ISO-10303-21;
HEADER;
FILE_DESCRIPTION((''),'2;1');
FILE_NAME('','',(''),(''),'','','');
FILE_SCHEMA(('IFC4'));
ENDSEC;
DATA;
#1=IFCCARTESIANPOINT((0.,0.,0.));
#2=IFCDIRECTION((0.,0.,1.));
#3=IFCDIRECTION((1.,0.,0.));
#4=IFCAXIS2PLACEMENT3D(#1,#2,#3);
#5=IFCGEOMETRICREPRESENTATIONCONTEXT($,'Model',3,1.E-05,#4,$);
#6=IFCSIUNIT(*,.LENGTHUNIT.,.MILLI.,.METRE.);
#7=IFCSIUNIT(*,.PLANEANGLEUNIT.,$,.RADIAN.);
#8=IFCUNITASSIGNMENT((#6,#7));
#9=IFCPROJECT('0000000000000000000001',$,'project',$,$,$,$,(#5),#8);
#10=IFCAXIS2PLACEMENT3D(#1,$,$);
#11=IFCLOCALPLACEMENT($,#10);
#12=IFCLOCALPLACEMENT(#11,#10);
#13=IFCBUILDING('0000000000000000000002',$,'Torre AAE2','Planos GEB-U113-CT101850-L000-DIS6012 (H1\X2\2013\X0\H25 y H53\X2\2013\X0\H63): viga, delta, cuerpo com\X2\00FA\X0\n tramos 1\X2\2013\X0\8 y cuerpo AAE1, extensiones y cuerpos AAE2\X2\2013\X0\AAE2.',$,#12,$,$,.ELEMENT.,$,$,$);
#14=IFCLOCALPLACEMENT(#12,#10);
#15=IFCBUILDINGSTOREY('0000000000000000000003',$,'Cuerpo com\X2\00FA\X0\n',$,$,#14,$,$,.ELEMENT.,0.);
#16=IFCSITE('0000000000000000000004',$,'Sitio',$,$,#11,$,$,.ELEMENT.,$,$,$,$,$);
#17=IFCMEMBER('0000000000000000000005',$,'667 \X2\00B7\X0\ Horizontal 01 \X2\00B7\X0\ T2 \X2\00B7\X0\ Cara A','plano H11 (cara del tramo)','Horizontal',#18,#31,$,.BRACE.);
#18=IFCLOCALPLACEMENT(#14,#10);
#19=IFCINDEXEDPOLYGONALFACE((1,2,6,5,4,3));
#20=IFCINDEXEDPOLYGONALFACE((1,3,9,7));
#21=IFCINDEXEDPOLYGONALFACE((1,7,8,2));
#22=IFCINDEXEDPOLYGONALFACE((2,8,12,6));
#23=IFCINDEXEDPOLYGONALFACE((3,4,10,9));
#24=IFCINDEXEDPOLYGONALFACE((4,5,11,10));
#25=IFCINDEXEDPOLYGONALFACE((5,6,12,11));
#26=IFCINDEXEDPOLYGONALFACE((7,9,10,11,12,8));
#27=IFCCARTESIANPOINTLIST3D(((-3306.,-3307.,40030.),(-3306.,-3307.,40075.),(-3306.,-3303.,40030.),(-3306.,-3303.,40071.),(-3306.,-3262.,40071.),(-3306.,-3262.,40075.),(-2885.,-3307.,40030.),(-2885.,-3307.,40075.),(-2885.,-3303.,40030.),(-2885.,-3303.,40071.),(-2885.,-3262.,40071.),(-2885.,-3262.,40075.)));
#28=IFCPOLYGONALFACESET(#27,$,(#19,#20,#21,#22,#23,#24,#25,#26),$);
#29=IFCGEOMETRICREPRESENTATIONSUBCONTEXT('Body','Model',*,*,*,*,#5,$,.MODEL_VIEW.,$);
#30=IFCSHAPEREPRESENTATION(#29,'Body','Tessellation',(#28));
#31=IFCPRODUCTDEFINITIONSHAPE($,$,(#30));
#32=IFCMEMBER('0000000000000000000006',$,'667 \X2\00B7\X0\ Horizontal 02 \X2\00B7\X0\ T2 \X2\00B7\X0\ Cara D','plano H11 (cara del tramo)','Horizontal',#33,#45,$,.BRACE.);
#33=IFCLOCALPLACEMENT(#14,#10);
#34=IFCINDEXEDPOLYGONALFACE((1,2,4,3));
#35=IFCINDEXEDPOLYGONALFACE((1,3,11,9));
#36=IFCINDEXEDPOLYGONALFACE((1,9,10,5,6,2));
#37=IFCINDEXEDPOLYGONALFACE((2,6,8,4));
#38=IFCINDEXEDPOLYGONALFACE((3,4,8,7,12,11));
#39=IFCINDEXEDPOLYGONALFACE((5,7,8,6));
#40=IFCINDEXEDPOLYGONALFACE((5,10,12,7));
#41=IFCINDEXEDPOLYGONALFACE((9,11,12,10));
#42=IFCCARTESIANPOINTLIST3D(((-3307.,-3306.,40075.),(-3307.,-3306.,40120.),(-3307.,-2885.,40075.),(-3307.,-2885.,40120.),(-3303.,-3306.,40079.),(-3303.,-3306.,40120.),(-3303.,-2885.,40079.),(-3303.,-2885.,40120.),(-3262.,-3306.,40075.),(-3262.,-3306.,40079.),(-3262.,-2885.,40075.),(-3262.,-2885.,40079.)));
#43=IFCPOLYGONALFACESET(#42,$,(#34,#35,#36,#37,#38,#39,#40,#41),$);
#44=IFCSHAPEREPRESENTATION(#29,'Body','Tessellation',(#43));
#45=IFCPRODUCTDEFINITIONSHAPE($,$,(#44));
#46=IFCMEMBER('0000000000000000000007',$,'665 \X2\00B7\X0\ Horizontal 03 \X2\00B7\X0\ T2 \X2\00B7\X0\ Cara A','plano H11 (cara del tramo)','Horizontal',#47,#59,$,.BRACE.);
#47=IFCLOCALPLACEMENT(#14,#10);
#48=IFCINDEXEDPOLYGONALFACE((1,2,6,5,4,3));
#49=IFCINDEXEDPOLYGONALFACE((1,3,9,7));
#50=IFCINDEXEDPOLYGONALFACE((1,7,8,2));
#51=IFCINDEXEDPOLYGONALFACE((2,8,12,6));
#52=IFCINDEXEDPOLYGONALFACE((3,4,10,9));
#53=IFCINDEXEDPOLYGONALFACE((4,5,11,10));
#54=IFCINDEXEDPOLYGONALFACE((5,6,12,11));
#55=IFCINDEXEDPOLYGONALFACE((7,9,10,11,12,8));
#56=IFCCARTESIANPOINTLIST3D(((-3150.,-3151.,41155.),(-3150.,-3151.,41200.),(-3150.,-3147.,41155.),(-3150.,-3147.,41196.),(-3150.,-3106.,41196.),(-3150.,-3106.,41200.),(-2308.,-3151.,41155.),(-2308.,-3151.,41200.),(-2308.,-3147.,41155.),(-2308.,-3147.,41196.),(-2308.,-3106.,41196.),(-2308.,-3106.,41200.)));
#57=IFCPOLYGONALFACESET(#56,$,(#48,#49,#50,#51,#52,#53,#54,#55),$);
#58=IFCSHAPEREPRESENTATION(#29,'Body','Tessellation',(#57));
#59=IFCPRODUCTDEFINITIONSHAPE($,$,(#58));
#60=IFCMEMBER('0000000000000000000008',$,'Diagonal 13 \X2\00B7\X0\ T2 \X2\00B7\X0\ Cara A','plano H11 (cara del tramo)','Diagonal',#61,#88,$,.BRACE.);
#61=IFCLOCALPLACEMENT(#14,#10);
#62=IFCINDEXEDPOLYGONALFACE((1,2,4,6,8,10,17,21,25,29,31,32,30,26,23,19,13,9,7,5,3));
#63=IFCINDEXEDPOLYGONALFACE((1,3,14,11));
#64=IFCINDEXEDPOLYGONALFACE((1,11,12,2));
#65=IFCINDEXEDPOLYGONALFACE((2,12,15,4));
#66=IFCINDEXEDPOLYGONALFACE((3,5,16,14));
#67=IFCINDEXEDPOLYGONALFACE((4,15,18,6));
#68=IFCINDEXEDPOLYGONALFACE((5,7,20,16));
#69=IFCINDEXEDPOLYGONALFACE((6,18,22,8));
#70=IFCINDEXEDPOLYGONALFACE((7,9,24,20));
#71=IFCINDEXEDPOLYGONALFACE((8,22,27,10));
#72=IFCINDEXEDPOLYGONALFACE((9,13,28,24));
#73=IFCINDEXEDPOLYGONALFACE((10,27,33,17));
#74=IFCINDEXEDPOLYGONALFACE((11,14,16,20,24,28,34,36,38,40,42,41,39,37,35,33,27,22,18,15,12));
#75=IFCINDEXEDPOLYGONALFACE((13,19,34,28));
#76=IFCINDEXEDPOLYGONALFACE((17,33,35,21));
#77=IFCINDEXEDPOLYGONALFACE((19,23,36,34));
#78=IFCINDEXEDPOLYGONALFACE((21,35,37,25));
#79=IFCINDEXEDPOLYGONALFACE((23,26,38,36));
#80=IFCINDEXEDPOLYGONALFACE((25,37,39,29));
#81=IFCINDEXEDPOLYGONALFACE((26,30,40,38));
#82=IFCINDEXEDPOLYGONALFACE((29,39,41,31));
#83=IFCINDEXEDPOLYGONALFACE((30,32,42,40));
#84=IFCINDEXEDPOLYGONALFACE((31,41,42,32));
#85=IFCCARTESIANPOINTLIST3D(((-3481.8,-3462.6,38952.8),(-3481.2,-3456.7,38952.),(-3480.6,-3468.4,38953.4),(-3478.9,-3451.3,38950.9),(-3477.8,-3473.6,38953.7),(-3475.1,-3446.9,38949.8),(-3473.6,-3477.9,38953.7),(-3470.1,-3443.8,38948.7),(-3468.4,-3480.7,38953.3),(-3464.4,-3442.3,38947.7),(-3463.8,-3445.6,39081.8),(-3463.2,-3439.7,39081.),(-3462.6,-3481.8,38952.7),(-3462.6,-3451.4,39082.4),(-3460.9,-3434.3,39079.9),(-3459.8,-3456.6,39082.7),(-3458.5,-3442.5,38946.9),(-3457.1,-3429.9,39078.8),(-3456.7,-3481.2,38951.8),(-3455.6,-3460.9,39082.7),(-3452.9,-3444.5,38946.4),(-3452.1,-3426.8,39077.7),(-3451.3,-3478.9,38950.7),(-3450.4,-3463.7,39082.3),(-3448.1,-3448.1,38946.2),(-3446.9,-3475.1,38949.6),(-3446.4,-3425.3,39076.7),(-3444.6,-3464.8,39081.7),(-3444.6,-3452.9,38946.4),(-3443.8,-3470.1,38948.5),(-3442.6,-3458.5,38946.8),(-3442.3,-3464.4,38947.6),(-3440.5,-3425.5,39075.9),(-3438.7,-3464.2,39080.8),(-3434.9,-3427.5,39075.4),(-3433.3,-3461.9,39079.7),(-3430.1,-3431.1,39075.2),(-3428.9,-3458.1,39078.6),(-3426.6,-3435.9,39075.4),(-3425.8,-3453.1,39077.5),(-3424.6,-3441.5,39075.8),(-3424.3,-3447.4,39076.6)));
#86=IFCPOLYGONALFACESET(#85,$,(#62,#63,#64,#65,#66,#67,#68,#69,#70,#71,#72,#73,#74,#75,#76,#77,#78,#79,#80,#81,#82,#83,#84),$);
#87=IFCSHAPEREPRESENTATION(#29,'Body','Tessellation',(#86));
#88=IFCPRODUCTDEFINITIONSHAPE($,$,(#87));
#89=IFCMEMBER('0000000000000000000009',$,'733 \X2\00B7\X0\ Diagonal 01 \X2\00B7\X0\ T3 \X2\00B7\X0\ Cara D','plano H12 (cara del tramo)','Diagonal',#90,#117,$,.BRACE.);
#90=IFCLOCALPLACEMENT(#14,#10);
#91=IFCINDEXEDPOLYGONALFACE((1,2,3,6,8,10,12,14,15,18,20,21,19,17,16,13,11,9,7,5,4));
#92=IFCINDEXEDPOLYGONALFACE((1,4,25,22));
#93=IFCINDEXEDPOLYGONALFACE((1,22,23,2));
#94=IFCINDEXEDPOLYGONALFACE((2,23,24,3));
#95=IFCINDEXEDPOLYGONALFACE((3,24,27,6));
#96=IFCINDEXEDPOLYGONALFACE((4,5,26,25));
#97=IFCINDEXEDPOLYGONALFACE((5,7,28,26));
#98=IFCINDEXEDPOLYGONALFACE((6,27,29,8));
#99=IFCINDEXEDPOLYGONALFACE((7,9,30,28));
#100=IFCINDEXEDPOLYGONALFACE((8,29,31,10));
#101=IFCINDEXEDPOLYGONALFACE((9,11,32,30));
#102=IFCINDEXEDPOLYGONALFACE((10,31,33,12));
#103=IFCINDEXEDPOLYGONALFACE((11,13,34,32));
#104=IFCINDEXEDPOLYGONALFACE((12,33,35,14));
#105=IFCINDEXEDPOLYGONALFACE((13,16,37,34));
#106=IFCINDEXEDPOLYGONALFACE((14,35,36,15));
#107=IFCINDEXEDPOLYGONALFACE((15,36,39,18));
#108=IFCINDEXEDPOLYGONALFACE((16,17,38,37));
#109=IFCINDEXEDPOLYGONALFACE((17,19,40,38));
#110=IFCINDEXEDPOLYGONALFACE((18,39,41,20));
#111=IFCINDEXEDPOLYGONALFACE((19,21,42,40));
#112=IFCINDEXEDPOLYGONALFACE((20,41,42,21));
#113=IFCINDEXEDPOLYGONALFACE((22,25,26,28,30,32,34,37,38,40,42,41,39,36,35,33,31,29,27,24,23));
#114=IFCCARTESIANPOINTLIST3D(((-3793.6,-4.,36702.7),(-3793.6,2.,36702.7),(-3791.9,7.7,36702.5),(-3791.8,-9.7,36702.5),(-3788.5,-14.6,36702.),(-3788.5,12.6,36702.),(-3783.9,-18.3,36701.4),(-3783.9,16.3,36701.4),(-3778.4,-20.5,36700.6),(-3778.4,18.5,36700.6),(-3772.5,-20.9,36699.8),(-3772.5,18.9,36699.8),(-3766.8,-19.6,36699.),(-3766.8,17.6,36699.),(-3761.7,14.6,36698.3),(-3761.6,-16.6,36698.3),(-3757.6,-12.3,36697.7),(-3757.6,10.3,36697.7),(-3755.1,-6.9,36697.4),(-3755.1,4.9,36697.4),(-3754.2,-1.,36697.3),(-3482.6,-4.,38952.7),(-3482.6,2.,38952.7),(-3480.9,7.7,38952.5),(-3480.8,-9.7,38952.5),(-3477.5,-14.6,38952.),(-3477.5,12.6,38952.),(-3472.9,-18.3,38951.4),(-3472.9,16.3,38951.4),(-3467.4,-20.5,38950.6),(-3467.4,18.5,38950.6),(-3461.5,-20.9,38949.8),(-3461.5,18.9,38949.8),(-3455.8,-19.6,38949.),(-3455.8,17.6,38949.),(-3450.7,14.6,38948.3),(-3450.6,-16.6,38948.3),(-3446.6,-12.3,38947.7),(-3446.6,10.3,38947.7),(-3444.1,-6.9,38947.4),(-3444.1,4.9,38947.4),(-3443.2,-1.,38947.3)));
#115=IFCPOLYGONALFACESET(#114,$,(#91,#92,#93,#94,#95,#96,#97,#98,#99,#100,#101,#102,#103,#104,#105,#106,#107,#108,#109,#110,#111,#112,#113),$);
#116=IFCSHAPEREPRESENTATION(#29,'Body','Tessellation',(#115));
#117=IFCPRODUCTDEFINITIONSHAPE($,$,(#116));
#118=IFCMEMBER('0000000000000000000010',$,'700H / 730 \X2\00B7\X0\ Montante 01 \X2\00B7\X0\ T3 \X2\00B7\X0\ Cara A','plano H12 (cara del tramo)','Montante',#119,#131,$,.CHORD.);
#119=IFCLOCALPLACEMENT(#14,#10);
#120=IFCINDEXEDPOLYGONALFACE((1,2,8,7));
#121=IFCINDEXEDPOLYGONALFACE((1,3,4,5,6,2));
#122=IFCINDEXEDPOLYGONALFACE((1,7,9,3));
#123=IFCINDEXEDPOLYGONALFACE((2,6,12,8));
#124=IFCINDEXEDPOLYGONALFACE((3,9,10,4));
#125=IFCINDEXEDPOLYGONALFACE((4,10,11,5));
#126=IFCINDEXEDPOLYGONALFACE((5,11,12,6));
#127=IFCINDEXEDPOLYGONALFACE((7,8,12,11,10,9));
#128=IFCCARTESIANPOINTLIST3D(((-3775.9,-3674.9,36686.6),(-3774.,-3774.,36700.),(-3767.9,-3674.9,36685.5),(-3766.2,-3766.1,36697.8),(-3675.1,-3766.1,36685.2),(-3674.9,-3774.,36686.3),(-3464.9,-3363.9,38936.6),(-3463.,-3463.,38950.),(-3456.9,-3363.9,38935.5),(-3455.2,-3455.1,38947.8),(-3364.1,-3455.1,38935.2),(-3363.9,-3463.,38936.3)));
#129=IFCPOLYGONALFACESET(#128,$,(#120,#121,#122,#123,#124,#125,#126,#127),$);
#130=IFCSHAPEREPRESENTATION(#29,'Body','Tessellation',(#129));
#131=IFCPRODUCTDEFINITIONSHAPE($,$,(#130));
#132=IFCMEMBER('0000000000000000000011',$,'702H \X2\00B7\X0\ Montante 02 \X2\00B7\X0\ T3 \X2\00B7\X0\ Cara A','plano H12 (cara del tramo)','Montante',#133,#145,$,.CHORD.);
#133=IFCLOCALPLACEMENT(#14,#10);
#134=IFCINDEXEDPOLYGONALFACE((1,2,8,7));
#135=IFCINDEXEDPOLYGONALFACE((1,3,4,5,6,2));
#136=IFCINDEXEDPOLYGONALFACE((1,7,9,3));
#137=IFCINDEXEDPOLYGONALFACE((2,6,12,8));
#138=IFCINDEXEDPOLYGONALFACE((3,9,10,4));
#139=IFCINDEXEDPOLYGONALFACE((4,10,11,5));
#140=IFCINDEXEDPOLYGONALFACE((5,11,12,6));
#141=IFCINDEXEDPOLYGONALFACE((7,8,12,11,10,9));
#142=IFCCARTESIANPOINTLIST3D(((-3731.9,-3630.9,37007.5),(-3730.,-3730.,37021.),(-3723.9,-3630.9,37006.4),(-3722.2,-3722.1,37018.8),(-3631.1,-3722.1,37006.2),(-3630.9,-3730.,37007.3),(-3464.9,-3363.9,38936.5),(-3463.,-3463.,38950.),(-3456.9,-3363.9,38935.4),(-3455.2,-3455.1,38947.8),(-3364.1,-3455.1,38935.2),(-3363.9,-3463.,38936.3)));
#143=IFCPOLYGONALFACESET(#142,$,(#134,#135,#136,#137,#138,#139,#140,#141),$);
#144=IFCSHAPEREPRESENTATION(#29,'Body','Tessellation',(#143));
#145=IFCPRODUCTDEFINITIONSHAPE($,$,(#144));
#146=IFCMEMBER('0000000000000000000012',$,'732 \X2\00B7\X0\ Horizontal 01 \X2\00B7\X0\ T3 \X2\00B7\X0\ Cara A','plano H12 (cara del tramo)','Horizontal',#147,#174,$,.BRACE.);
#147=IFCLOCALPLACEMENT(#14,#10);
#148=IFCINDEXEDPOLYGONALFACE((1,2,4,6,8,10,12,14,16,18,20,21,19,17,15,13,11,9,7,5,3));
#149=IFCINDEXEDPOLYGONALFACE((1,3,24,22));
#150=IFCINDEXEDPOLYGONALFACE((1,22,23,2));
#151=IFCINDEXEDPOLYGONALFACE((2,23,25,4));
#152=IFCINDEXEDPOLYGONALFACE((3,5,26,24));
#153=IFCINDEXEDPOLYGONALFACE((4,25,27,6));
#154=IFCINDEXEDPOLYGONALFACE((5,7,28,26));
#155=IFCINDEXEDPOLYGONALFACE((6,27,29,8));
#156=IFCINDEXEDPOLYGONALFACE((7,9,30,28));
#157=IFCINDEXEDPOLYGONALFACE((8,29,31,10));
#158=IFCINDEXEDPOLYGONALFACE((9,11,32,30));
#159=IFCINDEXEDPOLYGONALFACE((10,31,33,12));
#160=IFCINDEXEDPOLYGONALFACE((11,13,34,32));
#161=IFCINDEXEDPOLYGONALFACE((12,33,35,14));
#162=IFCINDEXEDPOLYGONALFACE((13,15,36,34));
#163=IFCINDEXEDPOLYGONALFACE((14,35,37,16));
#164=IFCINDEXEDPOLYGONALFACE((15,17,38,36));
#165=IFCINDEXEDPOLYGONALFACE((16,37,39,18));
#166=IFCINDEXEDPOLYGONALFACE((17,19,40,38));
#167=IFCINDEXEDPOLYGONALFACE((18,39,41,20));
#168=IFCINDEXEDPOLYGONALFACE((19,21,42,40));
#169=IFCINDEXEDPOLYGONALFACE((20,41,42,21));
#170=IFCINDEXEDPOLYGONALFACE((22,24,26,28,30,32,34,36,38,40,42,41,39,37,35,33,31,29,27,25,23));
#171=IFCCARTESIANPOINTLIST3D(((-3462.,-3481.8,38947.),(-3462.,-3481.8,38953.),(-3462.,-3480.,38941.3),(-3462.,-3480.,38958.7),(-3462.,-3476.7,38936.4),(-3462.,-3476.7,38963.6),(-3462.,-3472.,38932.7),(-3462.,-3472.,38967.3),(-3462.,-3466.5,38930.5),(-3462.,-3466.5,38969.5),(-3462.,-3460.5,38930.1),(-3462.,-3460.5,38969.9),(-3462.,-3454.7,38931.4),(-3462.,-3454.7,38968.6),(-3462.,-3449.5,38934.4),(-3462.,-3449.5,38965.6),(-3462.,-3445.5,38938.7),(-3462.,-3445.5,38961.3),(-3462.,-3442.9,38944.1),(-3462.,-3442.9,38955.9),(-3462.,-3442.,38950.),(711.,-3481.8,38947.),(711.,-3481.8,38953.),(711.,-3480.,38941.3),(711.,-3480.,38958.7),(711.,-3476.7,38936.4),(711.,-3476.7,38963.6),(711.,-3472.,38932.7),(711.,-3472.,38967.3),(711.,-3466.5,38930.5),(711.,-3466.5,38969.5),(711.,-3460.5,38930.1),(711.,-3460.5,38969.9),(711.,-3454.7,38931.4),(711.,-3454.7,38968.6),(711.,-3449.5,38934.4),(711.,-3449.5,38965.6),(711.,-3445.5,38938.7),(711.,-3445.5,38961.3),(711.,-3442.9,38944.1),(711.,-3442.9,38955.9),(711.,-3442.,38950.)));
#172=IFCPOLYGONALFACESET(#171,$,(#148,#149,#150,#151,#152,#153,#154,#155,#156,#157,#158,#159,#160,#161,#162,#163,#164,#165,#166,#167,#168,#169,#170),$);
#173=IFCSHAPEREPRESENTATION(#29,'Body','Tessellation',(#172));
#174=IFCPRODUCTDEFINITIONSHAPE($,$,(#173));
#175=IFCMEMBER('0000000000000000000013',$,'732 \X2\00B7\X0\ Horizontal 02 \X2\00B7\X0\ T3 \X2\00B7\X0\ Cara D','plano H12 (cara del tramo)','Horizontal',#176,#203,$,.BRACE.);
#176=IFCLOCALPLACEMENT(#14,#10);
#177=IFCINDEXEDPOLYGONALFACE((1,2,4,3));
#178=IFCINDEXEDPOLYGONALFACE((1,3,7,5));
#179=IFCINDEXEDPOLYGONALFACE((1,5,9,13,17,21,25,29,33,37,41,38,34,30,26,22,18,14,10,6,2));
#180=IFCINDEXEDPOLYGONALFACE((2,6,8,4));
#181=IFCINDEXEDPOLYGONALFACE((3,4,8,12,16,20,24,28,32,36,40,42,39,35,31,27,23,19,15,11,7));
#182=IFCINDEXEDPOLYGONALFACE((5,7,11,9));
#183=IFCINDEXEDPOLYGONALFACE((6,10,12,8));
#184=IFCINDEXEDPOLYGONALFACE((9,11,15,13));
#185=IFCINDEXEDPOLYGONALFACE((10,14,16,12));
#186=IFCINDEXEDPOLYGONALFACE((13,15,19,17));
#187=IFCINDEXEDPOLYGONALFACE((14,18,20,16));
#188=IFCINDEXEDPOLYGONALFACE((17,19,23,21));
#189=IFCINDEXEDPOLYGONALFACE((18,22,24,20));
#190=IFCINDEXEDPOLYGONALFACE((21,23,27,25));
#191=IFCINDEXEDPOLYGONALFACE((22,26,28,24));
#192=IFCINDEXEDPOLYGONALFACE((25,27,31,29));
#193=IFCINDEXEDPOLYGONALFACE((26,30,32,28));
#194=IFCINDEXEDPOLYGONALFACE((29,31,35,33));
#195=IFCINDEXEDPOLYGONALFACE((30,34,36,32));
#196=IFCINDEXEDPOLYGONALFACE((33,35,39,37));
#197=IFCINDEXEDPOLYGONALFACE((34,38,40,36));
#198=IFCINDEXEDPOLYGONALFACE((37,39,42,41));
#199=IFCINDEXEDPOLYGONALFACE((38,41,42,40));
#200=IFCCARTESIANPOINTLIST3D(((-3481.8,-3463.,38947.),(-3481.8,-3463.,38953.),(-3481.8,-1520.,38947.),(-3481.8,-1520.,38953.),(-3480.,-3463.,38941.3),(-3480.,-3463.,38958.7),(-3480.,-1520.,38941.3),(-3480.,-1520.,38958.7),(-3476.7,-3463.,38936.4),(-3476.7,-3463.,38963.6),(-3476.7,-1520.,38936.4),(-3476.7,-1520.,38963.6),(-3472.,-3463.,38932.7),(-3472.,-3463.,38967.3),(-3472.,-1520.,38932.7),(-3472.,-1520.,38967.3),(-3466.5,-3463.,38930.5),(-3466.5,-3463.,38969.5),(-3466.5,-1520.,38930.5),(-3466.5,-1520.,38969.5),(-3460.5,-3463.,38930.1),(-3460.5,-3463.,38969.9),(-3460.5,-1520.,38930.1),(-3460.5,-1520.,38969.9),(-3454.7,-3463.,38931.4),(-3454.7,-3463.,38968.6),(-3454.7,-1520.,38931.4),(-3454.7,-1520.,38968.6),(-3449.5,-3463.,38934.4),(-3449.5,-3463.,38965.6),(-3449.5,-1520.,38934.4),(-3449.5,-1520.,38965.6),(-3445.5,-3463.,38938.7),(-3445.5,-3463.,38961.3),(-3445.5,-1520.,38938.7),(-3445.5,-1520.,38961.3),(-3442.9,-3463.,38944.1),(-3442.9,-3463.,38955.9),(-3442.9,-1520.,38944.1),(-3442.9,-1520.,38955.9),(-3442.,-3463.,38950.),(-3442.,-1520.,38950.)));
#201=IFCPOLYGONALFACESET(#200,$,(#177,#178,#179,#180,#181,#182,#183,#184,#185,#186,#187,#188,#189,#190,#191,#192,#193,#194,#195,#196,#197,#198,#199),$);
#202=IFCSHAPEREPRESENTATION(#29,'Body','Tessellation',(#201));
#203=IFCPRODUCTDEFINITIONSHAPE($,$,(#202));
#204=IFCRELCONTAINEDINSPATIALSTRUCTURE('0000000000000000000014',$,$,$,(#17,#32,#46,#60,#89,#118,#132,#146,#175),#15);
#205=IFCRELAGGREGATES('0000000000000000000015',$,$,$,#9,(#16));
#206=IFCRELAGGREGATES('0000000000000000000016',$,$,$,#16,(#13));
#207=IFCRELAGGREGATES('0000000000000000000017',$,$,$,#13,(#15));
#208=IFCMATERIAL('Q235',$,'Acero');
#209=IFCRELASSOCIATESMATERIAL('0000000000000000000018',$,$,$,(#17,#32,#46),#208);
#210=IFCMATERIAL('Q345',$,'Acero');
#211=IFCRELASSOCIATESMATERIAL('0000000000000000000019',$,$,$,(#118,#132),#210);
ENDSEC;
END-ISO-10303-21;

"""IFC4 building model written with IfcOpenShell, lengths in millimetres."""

from ifc_helpers import new_model, si_unit, frame, frame_2d, origin, origin_with_axes, place, context, subcontext, project, spatial, circle, l_section, extrude, material, element, save


model = new_model("IFC4")

# Units and contexts
model_context = context("Model", 3, precision=1e-05, world=origin_with_axes())
body_context = subcontext(model_context, "Body", "Model", "MODEL_VIEW")
ifc_project = project(units=[si_unit("LENGTHUNIT", "METRE", prefix="MILLI"), si_unit("PLANEANGLEUNIT", "RADIAN")], contexts=[model_context])

# Site, building, storey
site_placement = place(None, origin())
site = spatial("IfcSite", under=ifc_project, at=site_placement, Name="Sitio", CompositionType="ELEMENT")
building_placement = place(site_placement, origin())
building = spatial("IfcBuilding", under=site, at=building_placement, Name="Torre AAE2", Description="Planos GEB-U113-CT101850-L000-DIS6012 (H1–H25 y H53–H63): viga, delta, cuerpo común tramos 1–8 y cuerpo AAE1, extensiones y cuerpos AAE2–AAE2.", CompositionType="ELEMENT")
storey_placement = place(building_placement, origin())
storey = spatial("IfcBuildingStorey", under=building, at=storey_placement, Name="Cuerpo común", CompositionType="ELEMENT", Elevation=0.0)

# Members
ifc_material_1 = material(Name="Q235", Category="Acero")
for number, where, z_axis, x_axis, name in (
    (1, (-2885.0, -3307.0, 40075.0), (-1.0, 0.0, 0.0), (0.0, 1.0, 0.0), "667 · Horizontal 01 · T2 · Cara A"),
    (2, (-3307.0, -2885.0, 40075.0), (0.0, -1.0, 0.0), (1.0, 0.0, 0.0), "667 · Horizontal 02 · T2 · Cara D"),
):
    element("IfcMember", number, at=place(storey_placement, frame(where, z_axis=z_axis, x_axis=x_axis)), inside=storey, material=ifc_material_1, Name=name, Description="plano H11 (cara del tramo)", ObjectType="Horizontal", PredefinedType="BRACE", context=body_context, shape_type="SweptSolid", body=[
        extrude(l_section(Depth=45.0, Width=45.0, Thickness=4.0, at=frame_2d((22.5, 22.5))), None, (0.0, 0.0, 1.0), 421.0),
    ])
member_1_placement = place(storey_placement, frame((-2308.0, -3151.0, 41200.0), z_axis=(-1.0, 0.0, 0.0), x_axis=(0.0, 1.0, 0.0)))
element("IfcMember", 3, at=member_1_placement, inside=storey, material=ifc_material_1, Name="665 · Horizontal 03 · T2 · Cara A", Description="plano H11 (cara del tramo)", ObjectType="Horizontal", PredefinedType="BRACE", context=body_context, shape_type="SweptSolid", body=[
    extrude(l_section(Depth=45.0, Width=45.0, Thickness=4.0, at=frame_2d((22.5, 22.5))), None, (0.0, 0.0, 1.0), 842.0),
])
member_2_placement = place(storey_placement, frame((-3444.0, -3445.0, 39079.0), z_axis=(-0.137034, -0.129421, -0.982075), x_axis=(0.69366, 0.695225, -0.188409)))
element("IfcMember", 4, at=member_2_placement, inside=storey, Name="Diagonal 13 · T2 · Cara A", Description="plano H11 (cara del tramo)", ObjectType="Diagonal", PredefinedType="BRACE", context=body_context, shape_type="SweptSolid", body=[
    extrude(circle(Radius=20.0), None, (0.0, 0.0, 1.0), 131.4),
])
member_3_placement = place(storey_placement, frame((-3774.0, -1.0, 36700.0), z_axis=(0.13692, 0.0, 0.990582), x_axis=(0.990582, 0.000279, -0.13692)))
element("IfcMember", 5, at=member_3_placement, inside=storey, Name="733 · Diagonal 01 · T3 · Cara D", Description="plano H12 (cara del tramo)", ObjectType="Diagonal", PredefinedType="BRACE", context=body_context, shape_type="SweptSolid", body=[
    extrude(circle(Radius=20.0), None, (0.0, 0.0, 1.0), 2271.4),
])
ifc_material_2 = material(Name="Q345", Category="Acero")
member_4_placement = place(storey_placement, frame((-3463.0, -3463.0, 38950.0), z_axis=(-0.135655, -0.135655, -0.981425), x_axis=(-0.018574, 0.990756, -0.134377)))
element("IfcMember", 6, at=member_4_placement, inside=storey, material=ifc_material_2, Name="700H / 730 · Montante 01 · T3 · Cara A", Description="plano H12 (cara del tramo)", ObjectType="Montante", PredefinedType="CHORD", context=body_context, shape_type="SweptSolid", body=[
    extrude(l_section(Depth=100.0, Width=100.0, Thickness=8.0, at=frame_2d((50.0, 50.0))), None, (0.0, 0.0, 1.0), 2292.6),
])
member_5_placement = place(storey_placement, frame((-3463.0, -3463.0, 38950.0), z_axis=(-0.135836, -0.135836, -0.981375), x_axis=(-0.018624, 0.990731, -0.134553)))
element("IfcMember", 7, at=member_5_placement, inside=storey, material=ifc_material_2, Name="702H · Montante 02 · T3 · Cara A", Description="plano H12 (cara del tramo)", ObjectType="Montante", PredefinedType="CHORD", context=body_context, shape_type="SweptSolid", body=[
    extrude(l_section(Depth=100.0, Width=100.0, Thickness=8.0, at=frame_2d((50.0, 50.0))), None, (0.0, 0.0, 1.0), 1965.6),
])
member_6_placement = place(storey_placement, frame((-3462.0, -3462.0, 38950.0), z_axis=(1.0, 0.0, 0.0), x_axis=(0.0, 1.0, 0.0)))
element("IfcMember", 8, at=member_6_placement, inside=storey, Name="732 · Horizontal 01 · T3 · Cara A", Description="plano H12 (cara del tramo)", ObjectType="Horizontal", PredefinedType="BRACE", context=body_context, shape_type="SweptSolid", body=[
    extrude(circle(Radius=20.0), None, (0.0, 0.0, 1.0), 4173.0),
])
member_7_placement = place(storey_placement, frame((-3462.0, -1520.0, 38950.0), z_axis=(0.0, -1.0, 0.0), x_axis=(1.0, 0.0, 0.0)))
element("IfcMember", 9, at=member_7_placement, inside=storey, Name="732 · Horizontal 02 · T3 · Cara D", Description="plano H12 (cara del tramo)", ObjectType="Horizontal", PredefinedType="BRACE", context=body_context, shape_type="SweptSolid", body=[
    extrude(circle(Radius=20.0), None, (0.0, 0.0, 1.0), 1943.0),
])

save(model, "model.ifc")
